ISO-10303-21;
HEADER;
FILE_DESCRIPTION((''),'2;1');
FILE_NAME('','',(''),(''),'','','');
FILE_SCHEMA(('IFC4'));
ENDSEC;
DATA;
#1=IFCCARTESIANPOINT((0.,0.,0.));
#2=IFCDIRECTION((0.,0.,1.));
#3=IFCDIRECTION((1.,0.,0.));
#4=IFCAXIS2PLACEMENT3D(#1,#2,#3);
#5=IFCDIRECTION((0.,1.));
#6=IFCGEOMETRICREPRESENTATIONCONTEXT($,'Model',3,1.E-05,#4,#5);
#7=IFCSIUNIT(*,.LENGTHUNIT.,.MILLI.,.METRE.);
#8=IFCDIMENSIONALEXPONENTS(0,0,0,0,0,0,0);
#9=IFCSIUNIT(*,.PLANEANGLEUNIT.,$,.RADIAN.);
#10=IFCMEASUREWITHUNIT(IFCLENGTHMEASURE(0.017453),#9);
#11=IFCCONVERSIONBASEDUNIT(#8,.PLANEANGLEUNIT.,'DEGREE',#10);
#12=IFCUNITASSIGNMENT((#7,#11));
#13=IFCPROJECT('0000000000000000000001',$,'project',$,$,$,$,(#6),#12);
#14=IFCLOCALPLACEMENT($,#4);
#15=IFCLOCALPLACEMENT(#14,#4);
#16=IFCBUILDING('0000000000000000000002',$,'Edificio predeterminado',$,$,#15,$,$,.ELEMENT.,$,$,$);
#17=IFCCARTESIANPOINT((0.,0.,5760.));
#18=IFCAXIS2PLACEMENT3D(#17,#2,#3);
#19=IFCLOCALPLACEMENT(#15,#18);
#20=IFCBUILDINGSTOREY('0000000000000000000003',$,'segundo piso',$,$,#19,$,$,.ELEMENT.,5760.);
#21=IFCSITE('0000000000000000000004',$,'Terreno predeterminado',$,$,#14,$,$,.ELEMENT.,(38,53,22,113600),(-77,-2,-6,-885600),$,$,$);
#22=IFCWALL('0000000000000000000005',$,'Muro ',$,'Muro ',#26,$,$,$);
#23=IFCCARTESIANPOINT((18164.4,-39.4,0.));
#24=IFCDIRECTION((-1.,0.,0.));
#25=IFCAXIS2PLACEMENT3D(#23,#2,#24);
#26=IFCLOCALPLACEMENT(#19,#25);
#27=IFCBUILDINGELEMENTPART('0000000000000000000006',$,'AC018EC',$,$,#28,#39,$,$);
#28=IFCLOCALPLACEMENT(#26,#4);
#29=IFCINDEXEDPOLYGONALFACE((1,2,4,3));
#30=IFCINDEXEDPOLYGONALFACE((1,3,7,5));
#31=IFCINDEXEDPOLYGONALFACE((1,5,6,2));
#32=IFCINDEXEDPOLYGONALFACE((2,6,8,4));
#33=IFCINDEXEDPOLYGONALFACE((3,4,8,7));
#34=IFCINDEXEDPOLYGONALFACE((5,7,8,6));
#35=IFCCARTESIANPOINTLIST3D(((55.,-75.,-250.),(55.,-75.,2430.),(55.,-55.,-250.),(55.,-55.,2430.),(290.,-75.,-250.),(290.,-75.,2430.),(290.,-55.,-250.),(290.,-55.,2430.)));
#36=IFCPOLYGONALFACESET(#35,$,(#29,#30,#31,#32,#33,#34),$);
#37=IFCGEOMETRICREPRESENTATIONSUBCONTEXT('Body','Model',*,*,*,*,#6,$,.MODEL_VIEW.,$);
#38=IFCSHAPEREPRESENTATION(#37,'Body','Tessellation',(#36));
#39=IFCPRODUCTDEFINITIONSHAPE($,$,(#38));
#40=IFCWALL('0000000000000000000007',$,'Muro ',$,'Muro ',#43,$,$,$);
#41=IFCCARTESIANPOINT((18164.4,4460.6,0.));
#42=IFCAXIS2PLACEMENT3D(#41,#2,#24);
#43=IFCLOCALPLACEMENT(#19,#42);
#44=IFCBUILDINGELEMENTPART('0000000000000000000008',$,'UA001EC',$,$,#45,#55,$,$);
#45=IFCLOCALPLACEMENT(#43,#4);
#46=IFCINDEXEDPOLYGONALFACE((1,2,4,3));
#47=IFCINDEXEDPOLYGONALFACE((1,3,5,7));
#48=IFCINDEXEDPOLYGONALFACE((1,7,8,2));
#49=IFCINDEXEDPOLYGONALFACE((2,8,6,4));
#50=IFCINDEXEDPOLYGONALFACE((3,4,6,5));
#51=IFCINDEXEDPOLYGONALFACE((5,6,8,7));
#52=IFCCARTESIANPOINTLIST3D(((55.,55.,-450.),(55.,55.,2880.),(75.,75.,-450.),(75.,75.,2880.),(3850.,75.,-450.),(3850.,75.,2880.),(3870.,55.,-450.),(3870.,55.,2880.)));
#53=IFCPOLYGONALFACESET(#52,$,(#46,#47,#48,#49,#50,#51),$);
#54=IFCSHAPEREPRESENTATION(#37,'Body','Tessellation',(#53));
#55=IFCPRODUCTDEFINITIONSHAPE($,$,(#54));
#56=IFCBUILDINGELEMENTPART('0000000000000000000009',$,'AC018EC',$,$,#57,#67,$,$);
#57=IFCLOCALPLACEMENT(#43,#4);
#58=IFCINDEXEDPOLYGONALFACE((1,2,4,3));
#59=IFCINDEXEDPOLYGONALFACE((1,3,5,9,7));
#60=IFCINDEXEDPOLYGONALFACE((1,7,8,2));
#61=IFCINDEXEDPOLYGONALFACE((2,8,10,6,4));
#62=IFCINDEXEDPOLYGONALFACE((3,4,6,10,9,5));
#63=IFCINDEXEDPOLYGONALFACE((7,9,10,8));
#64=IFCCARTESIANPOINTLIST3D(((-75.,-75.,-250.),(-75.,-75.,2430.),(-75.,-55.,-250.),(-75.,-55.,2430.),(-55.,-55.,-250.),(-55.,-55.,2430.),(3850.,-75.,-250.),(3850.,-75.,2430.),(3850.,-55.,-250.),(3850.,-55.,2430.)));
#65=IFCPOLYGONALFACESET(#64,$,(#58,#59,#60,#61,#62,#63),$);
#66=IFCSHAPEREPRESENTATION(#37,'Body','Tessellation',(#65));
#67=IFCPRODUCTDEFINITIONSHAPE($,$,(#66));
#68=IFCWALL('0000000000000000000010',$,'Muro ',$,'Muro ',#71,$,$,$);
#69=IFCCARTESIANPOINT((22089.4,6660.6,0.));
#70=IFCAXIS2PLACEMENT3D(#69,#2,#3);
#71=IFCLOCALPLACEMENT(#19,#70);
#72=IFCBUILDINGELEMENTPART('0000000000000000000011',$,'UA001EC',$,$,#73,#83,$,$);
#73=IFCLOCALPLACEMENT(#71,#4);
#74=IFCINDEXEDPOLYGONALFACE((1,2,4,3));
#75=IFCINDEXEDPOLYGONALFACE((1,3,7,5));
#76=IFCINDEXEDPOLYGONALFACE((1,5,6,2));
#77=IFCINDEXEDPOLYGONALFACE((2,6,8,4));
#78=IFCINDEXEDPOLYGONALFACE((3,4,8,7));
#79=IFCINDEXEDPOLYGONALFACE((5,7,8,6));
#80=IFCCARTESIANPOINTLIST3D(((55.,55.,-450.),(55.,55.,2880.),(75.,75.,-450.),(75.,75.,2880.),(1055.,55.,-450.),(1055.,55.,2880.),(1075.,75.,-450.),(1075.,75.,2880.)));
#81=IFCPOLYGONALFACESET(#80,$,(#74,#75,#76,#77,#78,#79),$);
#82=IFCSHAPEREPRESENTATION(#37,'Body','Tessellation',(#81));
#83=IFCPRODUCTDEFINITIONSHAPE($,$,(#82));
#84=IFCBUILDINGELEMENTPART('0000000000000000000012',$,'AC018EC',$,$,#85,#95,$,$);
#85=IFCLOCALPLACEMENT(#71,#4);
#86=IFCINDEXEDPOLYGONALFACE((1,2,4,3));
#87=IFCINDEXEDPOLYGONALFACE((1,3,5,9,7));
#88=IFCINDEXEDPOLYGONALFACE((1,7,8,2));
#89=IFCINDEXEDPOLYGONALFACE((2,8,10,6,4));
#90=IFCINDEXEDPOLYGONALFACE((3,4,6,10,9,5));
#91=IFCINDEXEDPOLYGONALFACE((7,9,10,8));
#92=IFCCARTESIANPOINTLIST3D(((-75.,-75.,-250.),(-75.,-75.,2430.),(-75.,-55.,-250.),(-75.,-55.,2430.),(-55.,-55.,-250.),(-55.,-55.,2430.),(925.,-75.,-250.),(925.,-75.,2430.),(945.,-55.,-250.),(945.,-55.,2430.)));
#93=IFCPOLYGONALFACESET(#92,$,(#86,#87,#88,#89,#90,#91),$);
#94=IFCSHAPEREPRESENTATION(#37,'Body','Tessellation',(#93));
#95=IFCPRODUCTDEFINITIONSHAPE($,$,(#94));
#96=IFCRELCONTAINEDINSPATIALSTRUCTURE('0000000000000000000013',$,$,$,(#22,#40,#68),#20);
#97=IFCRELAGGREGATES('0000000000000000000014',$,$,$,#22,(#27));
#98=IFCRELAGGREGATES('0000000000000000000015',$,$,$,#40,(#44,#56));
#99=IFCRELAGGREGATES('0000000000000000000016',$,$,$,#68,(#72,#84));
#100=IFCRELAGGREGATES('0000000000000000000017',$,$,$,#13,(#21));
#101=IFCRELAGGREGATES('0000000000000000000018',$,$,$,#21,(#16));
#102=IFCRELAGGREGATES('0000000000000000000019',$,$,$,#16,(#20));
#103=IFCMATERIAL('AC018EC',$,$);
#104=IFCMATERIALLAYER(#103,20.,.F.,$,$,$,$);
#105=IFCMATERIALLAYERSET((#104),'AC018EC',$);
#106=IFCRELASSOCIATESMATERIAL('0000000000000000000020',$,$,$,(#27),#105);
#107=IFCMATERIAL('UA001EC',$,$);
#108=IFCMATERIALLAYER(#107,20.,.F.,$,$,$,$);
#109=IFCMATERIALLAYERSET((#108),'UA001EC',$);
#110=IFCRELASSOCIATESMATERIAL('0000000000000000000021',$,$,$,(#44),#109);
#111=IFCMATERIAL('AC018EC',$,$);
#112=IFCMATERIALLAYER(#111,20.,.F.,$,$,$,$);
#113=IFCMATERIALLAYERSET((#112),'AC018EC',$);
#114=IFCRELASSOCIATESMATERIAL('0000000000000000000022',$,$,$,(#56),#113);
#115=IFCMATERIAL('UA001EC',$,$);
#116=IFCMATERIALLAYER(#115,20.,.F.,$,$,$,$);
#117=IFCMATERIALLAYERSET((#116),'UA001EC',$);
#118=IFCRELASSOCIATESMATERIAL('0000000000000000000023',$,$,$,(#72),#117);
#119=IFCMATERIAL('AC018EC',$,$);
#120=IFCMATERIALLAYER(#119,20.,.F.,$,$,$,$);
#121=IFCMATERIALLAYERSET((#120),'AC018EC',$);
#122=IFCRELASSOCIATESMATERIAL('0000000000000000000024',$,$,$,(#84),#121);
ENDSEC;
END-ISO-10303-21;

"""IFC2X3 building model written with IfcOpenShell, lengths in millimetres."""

from ifc_helpers import new_model, entity, si_unit, converted_unit, direction, frame, origin_with_axes, place, context, subcontext, project, spatial, polyline, outline, extrude, material, layer, layer_set, layer_usage, element, aggregate, save


model = new_model("IFC2X3")

# Units and contexts
model_context = context("Model", 3, precision=1e-05, world=origin_with_axes(), true_north=direction((0.0, 1.0)))
body_context = subcontext(model_context, "Body", "Model", "MODEL_VIEW")
ifc_project = project(units=[si_unit("LENGTHUNIT", "METRE", prefix="MILLI"), converted_unit("PLANEANGLEUNIT", "DEGREE", entity("IfcLengthMeasure", 0.017453), si_unit("PLANEANGLEUNIT", "RADIAN"), dimensions=[0, 0, 0, 0, 0, 0, 0])], contexts=[model_context])

# Site, building, storey
site_placement = place(None, origin_with_axes())
site = spatial("IfcSite", under=ifc_project, at=site_placement, Name="Terreno predeterminado", CompositionType="ELEMENT", RefLatitude=(38, 53, 22, 113600), RefLongitude=(-77, -2, -6, -885600))
building_placement = place(site_placement, origin_with_axes())
building = spatial("IfcBuilding", under=site, at=building_placement, Name="Edificio predeterminado", CompositionType="ELEMENT")
storey_placement = place(building_placement, frame((0.0, 0.0, 5760.0), z_axis=(0.0, 0.0, 1.0), x_axis=(1.0, 0.0, 0.0)))
storey = spatial("IfcBuildingStorey", under=building, at=storey_placement, Name="segundo piso", CompositionType="ELEMENT", Elevation=5760.0)

# Wall, building element part
wall_1_placement = place(storey_placement, frame((18164.4, -39.4, 0.0), z_axis=(0.0, 0.0, 1.0), x_axis=(-1.0, 0.0, 0.0)))
wall_1 = element("IfcWall", 1, at=wall_1_placement, inside=storey, Name="Muro ", ObjectType="Muro ")
ifc_material_1 = material(Name="AC018EC")
ifc_layer_1 = layer(ifc_material_1, 20.0, ventilated=False)
ifc_layer_set_1 = layer_set([ifc_layer_1], Name="AC018EC")
ifc_layer_usage_1 = layer_usage(ifc_layer_set_1, "AXIS2", "NEGATIVE", 55.0)
building_element_part_1_placement = place(wall_1_placement, origin_with_axes())
building_element_part_1 = element("IfcBuildingElementPart", 2, at=building_element_part_1_placement, material=ifc_layer_usage_1, Name="AC018EC", context=body_context, shape_type="SweptSolid", body=[
    extrude(outline(polyline([(290.0, -55.0), (290.0, -75.0), (55.0, -75.0), (55.0, -55.0), (290.0, -55.0)])), frame((0.0, 0.0, -250.0), z_axis=(0.0, 0.0, 1.0), x_axis=(1.0, 0.0, 0.0)), (0.0, 0.0, 1.0), 2680.0),
])
aggregate(wall_1, [building_element_part_1])

# Walls, building element parts
wall_2_placement = place(storey_placement, frame((18164.4, 4460.6, 0.0), z_axis=(0.0, 0.0, 1.0), x_axis=(-1.0, 0.0, 0.0)))
wall_2 = element("IfcWall", 3, at=wall_2_placement, inside=storey, Name="Muro ", ObjectType="Muro ")
ifc_material_2 = material(Name="UA001EC")
ifc_layer_2 = layer(ifc_material_2, 20.0, ventilated=False)
ifc_layer_set_2 = layer_set([ifc_layer_2], Name="UA001EC")
ifc_layer_usage_2 = layer_usage(ifc_layer_set_2, "AXIS2", "NEGATIVE", -75.0)
building_element_part_2_placement = place(wall_2_placement, origin_with_axes())
building_element_part_2 = element("IfcBuildingElementPart", 4, at=building_element_part_2_placement, material=ifc_layer_usage_2, Name="UA001EC", context=body_context, shape_type="SweptSolid", body=[
    extrude(outline(polyline([(3850.0, 75.0), (3870.0, 55.0), (55.0, 55.0), (75.0, 75.0), (3850.0, 75.0)])), frame((0.0, 0.0, -450.0), z_axis=(0.0, 0.0, 1.0), x_axis=(1.0, 0.0, 0.0)), (0.0, 0.0, 1.0), 3330.0),
])
ifc_material_3 = material(Name="AC018EC")
ifc_layer_3 = layer(ifc_material_3, 20.0, ventilated=False)
ifc_layer_set_3 = layer_set([ifc_layer_3], Name="AC018EC")
ifc_layer_usage_3 = layer_usage(ifc_layer_set_3, "AXIS2", "NEGATIVE", 55.0)
building_element_part_3_placement = place(wall_2_placement, origin_with_axes())
building_element_part_3 = element("IfcBuildingElementPart", 5, at=building_element_part_3_placement, material=ifc_layer_usage_3, Name="AC018EC", context=body_context, shape_type="SweptSolid", body=[
    extrude(outline(polyline([(3850.0, -55.0), (3850.0, -75.0), (-75.0, -75.0), (-75.0, -55.0), (-55.0, -55.0), (3850.0, -55.0)])), frame((0.0, 0.0, -250.0), z_axis=(0.0, 0.0, 1.0), x_axis=(1.0, 0.0, 0.0)), (0.0, 0.0, 1.0), 2680.0),
])
aggregate(wall_2, [building_element_part_2, building_element_part_3])
wall_3_placement = place(storey_placement, frame((22089.4, 6660.6, 0.0), z_axis=(0.0, 0.0, 1.0), x_axis=(1.0, 0.0, 0.0)))
wall_3 = element("IfcWall", 6, at=wall_3_placement, inside=storey, Name="Muro ", ObjectType="Muro ")
ifc_material_4 = material(Name="UA001EC")
ifc_layer_4 = layer(ifc_material_4, 20.0, ventilated=False)
ifc_layer_set_4 = layer_set([ifc_layer_4], Name="UA001EC")
ifc_layer_usage_4 = layer_usage(ifc_layer_set_4, "AXIS2", "NEGATIVE", -75.0)
building_element_part_4_placement = place(wall_3_placement, origin_with_axes())
building_element_part_4 = element("IfcBuildingElementPart", 7, at=building_element_part_4_placement, material=ifc_layer_usage_4, Name="UA001EC", context=body_context, shape_type="SweptSolid", body=[
    extrude(outline(polyline([(1075.0, 75.0), (1055.0, 55.0), (55.0, 55.0), (75.0, 75.0), (1075.0, 75.0)])), frame((0.0, 0.0, -450.0), z_axis=(0.0, 0.0, 1.0), x_axis=(1.0, 0.0, 0.0)), (0.0, 0.0, 1.0), 3330.0),
])
ifc_material_5 = material(Name="AC018EC")
ifc_layer_5 = layer(ifc_material_5, 20.0, ventilated=False)
ifc_layer_set_5 = layer_set([ifc_layer_5], Name="AC018EC")
ifc_layer_usage_5 = layer_usage(ifc_layer_set_5, "AXIS2", "NEGATIVE", 55.0)
building_element_part_5_placement = place(wall_3_placement, origin_with_axes())
building_element_part_5 = element("IfcBuildingElementPart", 8, at=building_element_part_5_placement, material=ifc_layer_usage_5, Name="AC018EC", context=body_context, shape_type="SweptSolid", body=[
    extrude(outline(polyline([(945.0, -55.0), (925.0, -75.0), (-75.0, -75.0), (-75.0, -55.0), (-55.0, -55.0), (945.0, -55.0)])), frame((0.0, 0.0, -250.0), z_axis=(0.0, 0.0, 1.0), x_axis=(1.0, 0.0, 0.0)), (0.0, 0.0, 1.0), 2680.0),
])
aggregate(wall_3, [building_element_part_4, building_element_part_5])

save(model, "model.ifc")
